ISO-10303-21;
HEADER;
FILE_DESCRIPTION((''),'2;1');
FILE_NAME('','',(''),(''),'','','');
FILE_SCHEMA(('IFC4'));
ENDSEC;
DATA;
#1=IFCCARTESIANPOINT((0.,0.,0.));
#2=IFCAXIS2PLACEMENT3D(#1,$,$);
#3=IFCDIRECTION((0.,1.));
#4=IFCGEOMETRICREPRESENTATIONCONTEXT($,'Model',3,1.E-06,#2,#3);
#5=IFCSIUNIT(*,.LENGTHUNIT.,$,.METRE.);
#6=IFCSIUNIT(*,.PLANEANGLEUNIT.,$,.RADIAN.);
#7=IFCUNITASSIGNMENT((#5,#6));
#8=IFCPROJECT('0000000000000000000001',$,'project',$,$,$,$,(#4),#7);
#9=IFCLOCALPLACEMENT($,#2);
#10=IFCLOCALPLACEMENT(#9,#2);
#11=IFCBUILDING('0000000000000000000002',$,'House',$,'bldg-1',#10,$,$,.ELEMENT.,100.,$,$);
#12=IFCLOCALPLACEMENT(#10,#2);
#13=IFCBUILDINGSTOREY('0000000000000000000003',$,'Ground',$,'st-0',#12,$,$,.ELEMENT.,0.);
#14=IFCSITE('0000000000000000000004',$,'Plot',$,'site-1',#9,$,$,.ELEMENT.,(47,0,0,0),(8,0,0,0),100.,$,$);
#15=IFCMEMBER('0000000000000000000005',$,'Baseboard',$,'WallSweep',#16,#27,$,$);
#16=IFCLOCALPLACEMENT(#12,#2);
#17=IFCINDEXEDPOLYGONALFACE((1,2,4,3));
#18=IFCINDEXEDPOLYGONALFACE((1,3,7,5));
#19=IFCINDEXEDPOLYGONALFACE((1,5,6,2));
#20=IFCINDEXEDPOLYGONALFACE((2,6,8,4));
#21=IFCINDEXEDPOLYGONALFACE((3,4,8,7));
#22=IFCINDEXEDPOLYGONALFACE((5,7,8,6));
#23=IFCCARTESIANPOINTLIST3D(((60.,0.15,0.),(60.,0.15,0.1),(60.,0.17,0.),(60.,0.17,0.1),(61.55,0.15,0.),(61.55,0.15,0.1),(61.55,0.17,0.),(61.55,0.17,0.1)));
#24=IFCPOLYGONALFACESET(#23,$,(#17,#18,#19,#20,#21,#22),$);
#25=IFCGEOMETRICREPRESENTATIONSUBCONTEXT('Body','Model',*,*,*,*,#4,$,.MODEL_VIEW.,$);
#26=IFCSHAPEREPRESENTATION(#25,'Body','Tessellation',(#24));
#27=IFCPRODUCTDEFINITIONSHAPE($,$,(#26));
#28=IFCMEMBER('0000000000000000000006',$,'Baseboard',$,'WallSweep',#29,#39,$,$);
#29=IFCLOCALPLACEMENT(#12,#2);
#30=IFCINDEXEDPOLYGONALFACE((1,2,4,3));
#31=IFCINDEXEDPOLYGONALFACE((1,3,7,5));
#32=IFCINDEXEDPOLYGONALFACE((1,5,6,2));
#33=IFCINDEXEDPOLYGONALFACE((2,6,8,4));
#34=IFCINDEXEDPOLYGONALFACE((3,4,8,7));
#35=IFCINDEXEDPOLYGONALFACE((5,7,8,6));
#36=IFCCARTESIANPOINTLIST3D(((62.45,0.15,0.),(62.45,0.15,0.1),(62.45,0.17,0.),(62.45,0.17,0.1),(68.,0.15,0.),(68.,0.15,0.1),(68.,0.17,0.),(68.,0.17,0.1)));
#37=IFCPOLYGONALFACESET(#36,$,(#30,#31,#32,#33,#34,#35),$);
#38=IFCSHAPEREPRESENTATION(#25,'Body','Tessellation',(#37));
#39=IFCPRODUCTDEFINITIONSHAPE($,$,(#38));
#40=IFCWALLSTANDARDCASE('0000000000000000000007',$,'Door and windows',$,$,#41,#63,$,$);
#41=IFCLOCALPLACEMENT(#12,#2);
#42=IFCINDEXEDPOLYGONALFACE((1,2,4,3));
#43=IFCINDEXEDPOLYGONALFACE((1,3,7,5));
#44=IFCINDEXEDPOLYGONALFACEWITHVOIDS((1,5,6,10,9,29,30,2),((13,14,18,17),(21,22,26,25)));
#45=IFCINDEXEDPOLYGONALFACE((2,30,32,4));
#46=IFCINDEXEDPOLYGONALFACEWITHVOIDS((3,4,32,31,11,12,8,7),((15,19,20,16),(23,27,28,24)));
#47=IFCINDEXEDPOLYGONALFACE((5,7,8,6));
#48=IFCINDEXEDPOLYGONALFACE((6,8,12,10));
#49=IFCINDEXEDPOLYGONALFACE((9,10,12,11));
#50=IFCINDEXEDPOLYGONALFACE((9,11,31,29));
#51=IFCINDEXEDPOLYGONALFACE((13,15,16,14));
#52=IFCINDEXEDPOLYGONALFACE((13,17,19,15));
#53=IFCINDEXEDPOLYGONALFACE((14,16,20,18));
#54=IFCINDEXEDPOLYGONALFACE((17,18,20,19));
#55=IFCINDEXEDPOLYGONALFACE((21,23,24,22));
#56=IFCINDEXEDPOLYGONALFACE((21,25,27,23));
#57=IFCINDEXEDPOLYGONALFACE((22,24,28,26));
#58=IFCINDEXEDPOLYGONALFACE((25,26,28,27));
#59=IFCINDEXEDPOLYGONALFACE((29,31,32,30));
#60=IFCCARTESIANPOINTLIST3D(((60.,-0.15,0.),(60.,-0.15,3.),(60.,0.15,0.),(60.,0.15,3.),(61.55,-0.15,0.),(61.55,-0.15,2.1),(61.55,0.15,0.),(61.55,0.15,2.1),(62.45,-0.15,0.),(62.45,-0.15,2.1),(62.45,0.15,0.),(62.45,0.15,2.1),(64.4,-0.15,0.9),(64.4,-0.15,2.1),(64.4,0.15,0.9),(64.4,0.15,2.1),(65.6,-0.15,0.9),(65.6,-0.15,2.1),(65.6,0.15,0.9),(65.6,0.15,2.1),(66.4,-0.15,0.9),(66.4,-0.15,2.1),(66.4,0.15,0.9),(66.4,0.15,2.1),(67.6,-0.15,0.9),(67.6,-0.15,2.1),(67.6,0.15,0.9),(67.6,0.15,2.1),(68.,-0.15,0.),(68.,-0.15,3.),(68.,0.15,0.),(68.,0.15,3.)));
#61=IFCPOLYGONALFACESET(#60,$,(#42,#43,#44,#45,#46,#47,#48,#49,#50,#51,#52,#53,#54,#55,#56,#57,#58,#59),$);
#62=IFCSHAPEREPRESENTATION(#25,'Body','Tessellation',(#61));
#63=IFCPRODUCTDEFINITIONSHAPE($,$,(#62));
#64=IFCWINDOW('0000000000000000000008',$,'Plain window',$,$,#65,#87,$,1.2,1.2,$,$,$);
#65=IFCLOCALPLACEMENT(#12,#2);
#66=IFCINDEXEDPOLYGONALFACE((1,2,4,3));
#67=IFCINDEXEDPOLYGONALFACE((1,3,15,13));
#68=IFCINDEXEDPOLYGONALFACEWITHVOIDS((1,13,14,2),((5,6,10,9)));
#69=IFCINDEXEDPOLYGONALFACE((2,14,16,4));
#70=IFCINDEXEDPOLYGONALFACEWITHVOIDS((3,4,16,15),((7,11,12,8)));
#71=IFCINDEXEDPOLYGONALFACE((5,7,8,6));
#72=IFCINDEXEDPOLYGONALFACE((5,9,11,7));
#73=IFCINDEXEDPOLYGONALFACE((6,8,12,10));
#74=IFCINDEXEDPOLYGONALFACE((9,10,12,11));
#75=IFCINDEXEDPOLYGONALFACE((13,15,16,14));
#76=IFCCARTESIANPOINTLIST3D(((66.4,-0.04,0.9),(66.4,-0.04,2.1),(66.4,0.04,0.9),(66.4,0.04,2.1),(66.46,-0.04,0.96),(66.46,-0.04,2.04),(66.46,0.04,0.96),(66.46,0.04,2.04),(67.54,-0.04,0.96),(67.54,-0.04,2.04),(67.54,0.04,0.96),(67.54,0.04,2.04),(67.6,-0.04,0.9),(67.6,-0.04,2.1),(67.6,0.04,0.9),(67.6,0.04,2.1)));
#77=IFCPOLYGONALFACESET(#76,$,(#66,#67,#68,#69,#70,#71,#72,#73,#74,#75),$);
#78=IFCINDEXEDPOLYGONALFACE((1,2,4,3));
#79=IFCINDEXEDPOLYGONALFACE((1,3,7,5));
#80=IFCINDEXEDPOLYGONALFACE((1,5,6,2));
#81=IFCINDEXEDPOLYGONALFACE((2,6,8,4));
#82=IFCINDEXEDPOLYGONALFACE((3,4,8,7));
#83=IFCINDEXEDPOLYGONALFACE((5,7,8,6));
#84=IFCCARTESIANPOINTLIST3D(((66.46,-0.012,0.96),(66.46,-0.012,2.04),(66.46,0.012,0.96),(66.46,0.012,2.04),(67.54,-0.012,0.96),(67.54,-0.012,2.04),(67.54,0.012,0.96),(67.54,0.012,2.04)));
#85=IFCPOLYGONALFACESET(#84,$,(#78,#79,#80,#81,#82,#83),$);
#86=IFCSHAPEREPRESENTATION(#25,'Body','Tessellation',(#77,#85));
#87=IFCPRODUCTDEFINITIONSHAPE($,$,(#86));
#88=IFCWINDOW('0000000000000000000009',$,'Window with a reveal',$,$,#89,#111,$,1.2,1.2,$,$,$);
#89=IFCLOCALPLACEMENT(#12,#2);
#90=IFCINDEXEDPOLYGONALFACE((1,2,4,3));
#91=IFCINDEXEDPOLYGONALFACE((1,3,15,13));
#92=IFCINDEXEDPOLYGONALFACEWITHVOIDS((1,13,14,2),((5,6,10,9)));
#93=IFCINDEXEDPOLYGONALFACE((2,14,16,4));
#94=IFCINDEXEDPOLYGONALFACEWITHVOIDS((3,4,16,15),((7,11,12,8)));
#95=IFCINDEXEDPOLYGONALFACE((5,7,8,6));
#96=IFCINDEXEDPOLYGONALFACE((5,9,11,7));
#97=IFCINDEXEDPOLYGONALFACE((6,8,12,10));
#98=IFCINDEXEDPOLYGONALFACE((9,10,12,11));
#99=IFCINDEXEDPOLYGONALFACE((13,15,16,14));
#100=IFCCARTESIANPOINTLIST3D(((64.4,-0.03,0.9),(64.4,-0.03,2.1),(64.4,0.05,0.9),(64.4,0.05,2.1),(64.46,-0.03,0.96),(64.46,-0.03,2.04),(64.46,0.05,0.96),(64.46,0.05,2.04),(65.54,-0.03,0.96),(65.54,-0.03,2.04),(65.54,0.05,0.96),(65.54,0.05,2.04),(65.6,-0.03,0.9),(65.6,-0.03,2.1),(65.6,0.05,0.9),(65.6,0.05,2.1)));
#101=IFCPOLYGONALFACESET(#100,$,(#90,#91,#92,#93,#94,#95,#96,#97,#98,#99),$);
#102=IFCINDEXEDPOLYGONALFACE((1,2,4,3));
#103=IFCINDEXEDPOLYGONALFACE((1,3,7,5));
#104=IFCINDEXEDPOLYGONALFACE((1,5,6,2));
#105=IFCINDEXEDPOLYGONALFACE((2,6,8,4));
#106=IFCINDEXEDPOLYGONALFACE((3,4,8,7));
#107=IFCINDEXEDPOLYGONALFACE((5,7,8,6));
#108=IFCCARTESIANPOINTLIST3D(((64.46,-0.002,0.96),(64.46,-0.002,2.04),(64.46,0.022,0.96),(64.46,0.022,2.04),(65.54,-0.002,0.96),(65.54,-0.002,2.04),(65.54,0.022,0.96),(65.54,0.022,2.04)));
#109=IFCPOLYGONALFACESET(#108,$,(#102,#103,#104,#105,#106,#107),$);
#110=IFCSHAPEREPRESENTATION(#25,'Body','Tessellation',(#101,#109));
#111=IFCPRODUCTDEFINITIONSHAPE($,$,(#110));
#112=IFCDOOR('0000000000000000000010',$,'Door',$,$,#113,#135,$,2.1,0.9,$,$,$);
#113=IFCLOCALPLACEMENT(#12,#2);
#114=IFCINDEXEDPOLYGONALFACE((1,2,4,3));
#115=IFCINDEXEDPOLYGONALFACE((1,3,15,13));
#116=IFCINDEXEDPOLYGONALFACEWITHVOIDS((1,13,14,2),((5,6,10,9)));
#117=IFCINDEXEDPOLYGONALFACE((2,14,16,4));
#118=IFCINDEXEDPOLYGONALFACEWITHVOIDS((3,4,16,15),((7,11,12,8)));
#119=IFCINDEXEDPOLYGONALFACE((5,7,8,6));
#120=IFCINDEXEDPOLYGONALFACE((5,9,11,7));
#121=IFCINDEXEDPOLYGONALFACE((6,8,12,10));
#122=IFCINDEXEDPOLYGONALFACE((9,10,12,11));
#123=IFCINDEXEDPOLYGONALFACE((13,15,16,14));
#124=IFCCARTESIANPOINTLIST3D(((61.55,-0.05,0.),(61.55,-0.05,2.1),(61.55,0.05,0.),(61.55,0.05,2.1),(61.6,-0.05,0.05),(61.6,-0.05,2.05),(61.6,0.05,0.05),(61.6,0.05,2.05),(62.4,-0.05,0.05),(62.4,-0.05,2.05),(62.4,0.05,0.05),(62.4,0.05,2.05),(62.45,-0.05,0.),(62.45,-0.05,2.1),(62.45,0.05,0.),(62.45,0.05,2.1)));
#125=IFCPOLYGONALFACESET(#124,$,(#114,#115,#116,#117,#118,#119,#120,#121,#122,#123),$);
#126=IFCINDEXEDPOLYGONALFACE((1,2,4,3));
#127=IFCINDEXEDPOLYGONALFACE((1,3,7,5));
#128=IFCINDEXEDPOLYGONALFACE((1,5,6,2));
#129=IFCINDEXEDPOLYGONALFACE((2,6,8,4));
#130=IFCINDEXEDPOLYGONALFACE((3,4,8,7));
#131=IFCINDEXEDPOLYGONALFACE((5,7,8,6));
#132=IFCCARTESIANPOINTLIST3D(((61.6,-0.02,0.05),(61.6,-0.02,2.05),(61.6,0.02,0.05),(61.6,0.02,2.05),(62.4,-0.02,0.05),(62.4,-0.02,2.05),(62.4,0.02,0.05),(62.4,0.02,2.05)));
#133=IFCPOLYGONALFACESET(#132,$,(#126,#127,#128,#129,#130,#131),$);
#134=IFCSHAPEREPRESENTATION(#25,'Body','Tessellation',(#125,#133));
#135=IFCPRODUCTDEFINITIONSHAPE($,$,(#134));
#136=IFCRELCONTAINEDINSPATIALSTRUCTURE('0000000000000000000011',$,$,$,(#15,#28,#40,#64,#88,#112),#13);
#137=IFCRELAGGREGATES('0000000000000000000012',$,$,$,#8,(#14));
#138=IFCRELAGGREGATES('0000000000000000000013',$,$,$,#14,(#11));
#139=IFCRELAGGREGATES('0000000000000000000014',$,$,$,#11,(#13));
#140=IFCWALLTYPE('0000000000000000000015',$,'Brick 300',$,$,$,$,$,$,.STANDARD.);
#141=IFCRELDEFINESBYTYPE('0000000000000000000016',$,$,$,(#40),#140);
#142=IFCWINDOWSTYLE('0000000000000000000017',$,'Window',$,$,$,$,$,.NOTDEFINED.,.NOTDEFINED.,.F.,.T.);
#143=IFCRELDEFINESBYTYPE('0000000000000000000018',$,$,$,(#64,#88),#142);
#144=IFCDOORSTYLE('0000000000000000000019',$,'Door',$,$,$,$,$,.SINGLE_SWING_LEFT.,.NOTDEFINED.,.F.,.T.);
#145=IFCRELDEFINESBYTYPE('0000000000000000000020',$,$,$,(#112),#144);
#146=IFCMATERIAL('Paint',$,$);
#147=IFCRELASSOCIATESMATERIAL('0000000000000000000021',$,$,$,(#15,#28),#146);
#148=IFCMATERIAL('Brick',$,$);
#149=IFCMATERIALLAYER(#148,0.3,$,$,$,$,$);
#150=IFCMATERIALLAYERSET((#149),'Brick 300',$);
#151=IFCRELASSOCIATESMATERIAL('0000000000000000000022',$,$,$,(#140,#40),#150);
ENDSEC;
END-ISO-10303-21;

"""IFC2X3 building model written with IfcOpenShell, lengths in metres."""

from ifc_helpers import new_model, si_unit, direction, frame, frame_2d, origin, origin_2d, place, context, subcontext, project, spatial, polyline, rectangle, outline, extrude, material, layer, layer_set, layer_usage, type_object, element, fill, save


model = new_model("IFC2X3")

# Units and contexts
model_context = context("Model", 3, precision=1e-06, world=origin(), true_north=direction((0.0, 1.0)))
body_context = subcontext(model_context, "Body", "Model", "MODEL_VIEW")
ifc_project = project(units=[si_unit("LENGTHUNIT", "METRE"), si_unit("PLANEANGLEUNIT", "RADIAN")], contexts=[model_context])

# Site, building, storey
site_placement = place(None, origin())
site = spatial("IfcSite", under=ifc_project, at=site_placement, Name="Plot", ObjectType="site-1", CompositionType="ELEMENT", RefLatitude=(47, 0, 0, 0), RefLongitude=(8, 0, 0, 0), RefElevation=100.0)
building_placement = place(site_placement, origin())
building = spatial("IfcBuilding", under=site, at=building_placement, Name="House", ObjectType="bldg-1", CompositionType="ELEMENT", ElevationOfRefHeight=100.0)
storey_placement = place(building_placement, origin())
storey = spatial("IfcBuildingStorey", under=building, at=storey_placement, Name="Ground", ObjectType="st-0", CompositionType="ELEMENT", Elevation=0.0)

# Members
ifc_material_1 = material(Name="Paint")
member_1_placement = place(storey_placement, origin())
element("IfcMember", 1, at=member_1_placement, inside=storey, material=ifc_material_1, Name="Baseboard", ObjectType="WallSweep", context=body_context, shape_type="SweptSolid", body=[
    extrude(outline(polyline([(0.0, 0.0), (0.02, 0.0), (0.02, 0.1), (0.0, 0.1), (0.0, 0.0)])), frame((60.0, 0.15, 0.0), z_axis=(1.0, 0.0, 0.0), x_axis=(0.0, 1.0, 0.0)), (0.0, 0.0, 1.0), 1.55),
])
member_2_placement = place(storey_placement, origin())
element("IfcMember", 2, at=member_2_placement, inside=storey, material=ifc_material_1, Name="Baseboard", ObjectType="WallSweep", context=body_context, shape_type="SweptSolid", body=[
    extrude(outline(polyline([(0.0, 0.0), (0.02, 0.0), (0.02, 0.1), (0.0, 0.1), (0.0, 0.0)])), frame((62.45, 0.15, 0.0), z_axis=(1.0, 0.0, 0.0), x_axis=(0.0, 1.0, 0.0)), (0.0, 0.0, 1.0), 5.55),
])

# Wall, openings, windows, door
ifc_material_2 = material(Name="Brick")
ifc_layer = layer(ifc_material_2, 0.3)
ifc_layer_set = layer_set([ifc_layer], Name="Brick 300")
ifc_layer_usage = layer_usage(ifc_layer_set, "AXIS2", "NEGATIVE", 0.15)
wall_type = type_object("IfcWallType", Name="Brick 300", PredefinedType="STANDARD", material=ifc_layer_set)
wall_placement = place(storey_placement, frame((60.0, 0.0, 0.0), z_axis=(0.0, 0.0, 1.0), x_axis=(1.0, 0.0, 0.0)))
wall = element("IfcWallStandardCase", 3, at=wall_placement, inside=storey, type_object=wall_type, material=ifc_layer_usage, Name="Door and windows", context=body_context, shape_type="SweptSolid", body=[
    extrude(rectangle(XDim=8.0, YDim=0.3, at=frame_2d((4.0, 0.0))), origin(), (0.0, 0.0, 1.0), 3.0),
])
opening_1_placement = place(wall_placement, frame((2.0, 0.0, 0.0)))
opening_1 = element("IfcOpeningElement", 4, at=opening_1_placement, cuts=wall, context=body_context, shape_type="SweptSolid", body=[
    extrude(rectangle(XDim=0.9, YDim=0.3, at=origin_2d()), origin(), (0.0, 0.0, 1.0), 2.1),
])
opening_2_placement = place(wall_placement, frame((7.0, 0.0, 0.9)))
opening_2 = element("IfcOpeningElement", 5, at=opening_2_placement, cuts=wall, context=body_context, shape_type="SweptSolid", body=[
    extrude(rectangle(XDim=1.2, YDim=0.3, at=origin_2d()), origin(), (0.0, 0.0, 1.0), 1.2),
])
opening_3_placement = place(wall_placement, frame((5.0, 0.0, 0.9)))
opening_3 = element("IfcOpeningElement", 6, at=opening_3_placement, cuts=wall, context=body_context, shape_type="SweptSolid", body=[
    extrude(rectangle(XDim=1.2, YDim=0.3, at=origin_2d()), origin(), (0.0, 0.0, 1.0), 1.2),
])
window_style = type_object("IfcWindowStyle", Name="Window", ConstructionType="NOTDEFINED", OperationType="NOTDEFINED", ParameterTakesPrecedence=False, Sizeable=True)
window_1_placement = place(opening_2_placement, frame((0.0, 0.0, 0.0), z_axis=(0.0, -1.0, 0.0), x_axis=(1.0, 0.0, 0.0)))
window_1 = element("IfcWindow", 7, at=window_1_placement, inside=storey, type_object=window_style, Name="Plain window", OverallHeight=1.2, OverallWidth=1.2, context=body_context, shape_type="SweptSolid", body=[
    extrude(outline(polyline([(-0.6, 0.0), (0.6, 0.0), (0.6, 1.2), (-0.6, 1.2), (-0.6, 0.0)]), holes=[polyline([(-0.54, 0.06), (0.54, 0.06), (0.54, 1.14), (-0.54, 1.14), (-0.54, 0.06)])]), frame((0.0, 0.0, -0.04)), (0.0, 0.0, 1.0), 0.08),
    extrude(rectangle(XDim=1.08, YDim=1.08, at=frame_2d((0.0, 0.6))), frame((0.0, 0.0, -0.012)), (0.0, 0.0, 1.0), 0.024),
])
fill(opening_2, window_1)
window_2_placement = place(opening_3_placement, frame((0.0, 0.01, 0.0), z_axis=(0.0, -1.0, 0.0), x_axis=(1.0, 0.0, 0.0)))
window_2 = element("IfcWindow", 8, at=window_2_placement, inside=storey, type_object=window_style, Name="Window with a reveal", OverallHeight=1.2, OverallWidth=1.2, context=body_context, shape_type="SweptSolid", body=[
    extrude(outline(polyline([(-0.6, 0.0), (0.6, 0.0), (0.6, 1.2), (-0.6, 1.2), (-0.6, 0.0)]), holes=[polyline([(-0.54, 0.06), (0.54, 0.06), (0.54, 1.14), (-0.54, 1.14), (-0.54, 0.06)])]), frame((0.0, 0.0, -0.04)), (0.0, 0.0, 1.0), 0.08),
    extrude(rectangle(XDim=1.08, YDim=1.08, at=frame_2d((0.0, 0.6))), frame((0.0, 0.0, -0.012)), (0.0, 0.0, 1.0), 0.024),
])
fill(opening_3, window_2)
door_style = type_object("IfcDoorStyle", Name="Door", ConstructionType="NOTDEFINED", OperationType="SINGLE_SWING_LEFT", ParameterTakesPrecedence=False, Sizeable=True)
door_placement = place(opening_1_placement, frame((0.0, 0.0, 0.0), z_axis=(0.0, -1.0, 0.0), x_axis=(1.0, 0.0, 0.0)))
door = element("IfcDoor", 9, at=door_placement, inside=storey, type_object=door_style, Name="Door", OverallHeight=2.1, OverallWidth=0.9, context=body_context, shape_type="SweptSolid", body=[
    extrude(outline(polyline([(-0.45, 0.0), (0.45, 0.0), (0.45, 2.1), (-0.45, 2.1), (-0.45, 0.0)]), holes=[polyline([(-0.4, 0.05), (0.4, 0.05), (0.4, 2.05), (-0.4, 2.05), (-0.4, 0.05)])]), frame((0.0, 0.0, -0.05)), (0.0, 0.0, 1.0), 0.1),
    extrude(rectangle(XDim=0.8, YDim=2.0, at=frame_2d((0.0, 1.05))), frame((0.0, 0.0, -0.02)), (0.0, 0.0, 1.0), 0.04),
])
fill(opening_1, door)

save(model, "model.ifc")
